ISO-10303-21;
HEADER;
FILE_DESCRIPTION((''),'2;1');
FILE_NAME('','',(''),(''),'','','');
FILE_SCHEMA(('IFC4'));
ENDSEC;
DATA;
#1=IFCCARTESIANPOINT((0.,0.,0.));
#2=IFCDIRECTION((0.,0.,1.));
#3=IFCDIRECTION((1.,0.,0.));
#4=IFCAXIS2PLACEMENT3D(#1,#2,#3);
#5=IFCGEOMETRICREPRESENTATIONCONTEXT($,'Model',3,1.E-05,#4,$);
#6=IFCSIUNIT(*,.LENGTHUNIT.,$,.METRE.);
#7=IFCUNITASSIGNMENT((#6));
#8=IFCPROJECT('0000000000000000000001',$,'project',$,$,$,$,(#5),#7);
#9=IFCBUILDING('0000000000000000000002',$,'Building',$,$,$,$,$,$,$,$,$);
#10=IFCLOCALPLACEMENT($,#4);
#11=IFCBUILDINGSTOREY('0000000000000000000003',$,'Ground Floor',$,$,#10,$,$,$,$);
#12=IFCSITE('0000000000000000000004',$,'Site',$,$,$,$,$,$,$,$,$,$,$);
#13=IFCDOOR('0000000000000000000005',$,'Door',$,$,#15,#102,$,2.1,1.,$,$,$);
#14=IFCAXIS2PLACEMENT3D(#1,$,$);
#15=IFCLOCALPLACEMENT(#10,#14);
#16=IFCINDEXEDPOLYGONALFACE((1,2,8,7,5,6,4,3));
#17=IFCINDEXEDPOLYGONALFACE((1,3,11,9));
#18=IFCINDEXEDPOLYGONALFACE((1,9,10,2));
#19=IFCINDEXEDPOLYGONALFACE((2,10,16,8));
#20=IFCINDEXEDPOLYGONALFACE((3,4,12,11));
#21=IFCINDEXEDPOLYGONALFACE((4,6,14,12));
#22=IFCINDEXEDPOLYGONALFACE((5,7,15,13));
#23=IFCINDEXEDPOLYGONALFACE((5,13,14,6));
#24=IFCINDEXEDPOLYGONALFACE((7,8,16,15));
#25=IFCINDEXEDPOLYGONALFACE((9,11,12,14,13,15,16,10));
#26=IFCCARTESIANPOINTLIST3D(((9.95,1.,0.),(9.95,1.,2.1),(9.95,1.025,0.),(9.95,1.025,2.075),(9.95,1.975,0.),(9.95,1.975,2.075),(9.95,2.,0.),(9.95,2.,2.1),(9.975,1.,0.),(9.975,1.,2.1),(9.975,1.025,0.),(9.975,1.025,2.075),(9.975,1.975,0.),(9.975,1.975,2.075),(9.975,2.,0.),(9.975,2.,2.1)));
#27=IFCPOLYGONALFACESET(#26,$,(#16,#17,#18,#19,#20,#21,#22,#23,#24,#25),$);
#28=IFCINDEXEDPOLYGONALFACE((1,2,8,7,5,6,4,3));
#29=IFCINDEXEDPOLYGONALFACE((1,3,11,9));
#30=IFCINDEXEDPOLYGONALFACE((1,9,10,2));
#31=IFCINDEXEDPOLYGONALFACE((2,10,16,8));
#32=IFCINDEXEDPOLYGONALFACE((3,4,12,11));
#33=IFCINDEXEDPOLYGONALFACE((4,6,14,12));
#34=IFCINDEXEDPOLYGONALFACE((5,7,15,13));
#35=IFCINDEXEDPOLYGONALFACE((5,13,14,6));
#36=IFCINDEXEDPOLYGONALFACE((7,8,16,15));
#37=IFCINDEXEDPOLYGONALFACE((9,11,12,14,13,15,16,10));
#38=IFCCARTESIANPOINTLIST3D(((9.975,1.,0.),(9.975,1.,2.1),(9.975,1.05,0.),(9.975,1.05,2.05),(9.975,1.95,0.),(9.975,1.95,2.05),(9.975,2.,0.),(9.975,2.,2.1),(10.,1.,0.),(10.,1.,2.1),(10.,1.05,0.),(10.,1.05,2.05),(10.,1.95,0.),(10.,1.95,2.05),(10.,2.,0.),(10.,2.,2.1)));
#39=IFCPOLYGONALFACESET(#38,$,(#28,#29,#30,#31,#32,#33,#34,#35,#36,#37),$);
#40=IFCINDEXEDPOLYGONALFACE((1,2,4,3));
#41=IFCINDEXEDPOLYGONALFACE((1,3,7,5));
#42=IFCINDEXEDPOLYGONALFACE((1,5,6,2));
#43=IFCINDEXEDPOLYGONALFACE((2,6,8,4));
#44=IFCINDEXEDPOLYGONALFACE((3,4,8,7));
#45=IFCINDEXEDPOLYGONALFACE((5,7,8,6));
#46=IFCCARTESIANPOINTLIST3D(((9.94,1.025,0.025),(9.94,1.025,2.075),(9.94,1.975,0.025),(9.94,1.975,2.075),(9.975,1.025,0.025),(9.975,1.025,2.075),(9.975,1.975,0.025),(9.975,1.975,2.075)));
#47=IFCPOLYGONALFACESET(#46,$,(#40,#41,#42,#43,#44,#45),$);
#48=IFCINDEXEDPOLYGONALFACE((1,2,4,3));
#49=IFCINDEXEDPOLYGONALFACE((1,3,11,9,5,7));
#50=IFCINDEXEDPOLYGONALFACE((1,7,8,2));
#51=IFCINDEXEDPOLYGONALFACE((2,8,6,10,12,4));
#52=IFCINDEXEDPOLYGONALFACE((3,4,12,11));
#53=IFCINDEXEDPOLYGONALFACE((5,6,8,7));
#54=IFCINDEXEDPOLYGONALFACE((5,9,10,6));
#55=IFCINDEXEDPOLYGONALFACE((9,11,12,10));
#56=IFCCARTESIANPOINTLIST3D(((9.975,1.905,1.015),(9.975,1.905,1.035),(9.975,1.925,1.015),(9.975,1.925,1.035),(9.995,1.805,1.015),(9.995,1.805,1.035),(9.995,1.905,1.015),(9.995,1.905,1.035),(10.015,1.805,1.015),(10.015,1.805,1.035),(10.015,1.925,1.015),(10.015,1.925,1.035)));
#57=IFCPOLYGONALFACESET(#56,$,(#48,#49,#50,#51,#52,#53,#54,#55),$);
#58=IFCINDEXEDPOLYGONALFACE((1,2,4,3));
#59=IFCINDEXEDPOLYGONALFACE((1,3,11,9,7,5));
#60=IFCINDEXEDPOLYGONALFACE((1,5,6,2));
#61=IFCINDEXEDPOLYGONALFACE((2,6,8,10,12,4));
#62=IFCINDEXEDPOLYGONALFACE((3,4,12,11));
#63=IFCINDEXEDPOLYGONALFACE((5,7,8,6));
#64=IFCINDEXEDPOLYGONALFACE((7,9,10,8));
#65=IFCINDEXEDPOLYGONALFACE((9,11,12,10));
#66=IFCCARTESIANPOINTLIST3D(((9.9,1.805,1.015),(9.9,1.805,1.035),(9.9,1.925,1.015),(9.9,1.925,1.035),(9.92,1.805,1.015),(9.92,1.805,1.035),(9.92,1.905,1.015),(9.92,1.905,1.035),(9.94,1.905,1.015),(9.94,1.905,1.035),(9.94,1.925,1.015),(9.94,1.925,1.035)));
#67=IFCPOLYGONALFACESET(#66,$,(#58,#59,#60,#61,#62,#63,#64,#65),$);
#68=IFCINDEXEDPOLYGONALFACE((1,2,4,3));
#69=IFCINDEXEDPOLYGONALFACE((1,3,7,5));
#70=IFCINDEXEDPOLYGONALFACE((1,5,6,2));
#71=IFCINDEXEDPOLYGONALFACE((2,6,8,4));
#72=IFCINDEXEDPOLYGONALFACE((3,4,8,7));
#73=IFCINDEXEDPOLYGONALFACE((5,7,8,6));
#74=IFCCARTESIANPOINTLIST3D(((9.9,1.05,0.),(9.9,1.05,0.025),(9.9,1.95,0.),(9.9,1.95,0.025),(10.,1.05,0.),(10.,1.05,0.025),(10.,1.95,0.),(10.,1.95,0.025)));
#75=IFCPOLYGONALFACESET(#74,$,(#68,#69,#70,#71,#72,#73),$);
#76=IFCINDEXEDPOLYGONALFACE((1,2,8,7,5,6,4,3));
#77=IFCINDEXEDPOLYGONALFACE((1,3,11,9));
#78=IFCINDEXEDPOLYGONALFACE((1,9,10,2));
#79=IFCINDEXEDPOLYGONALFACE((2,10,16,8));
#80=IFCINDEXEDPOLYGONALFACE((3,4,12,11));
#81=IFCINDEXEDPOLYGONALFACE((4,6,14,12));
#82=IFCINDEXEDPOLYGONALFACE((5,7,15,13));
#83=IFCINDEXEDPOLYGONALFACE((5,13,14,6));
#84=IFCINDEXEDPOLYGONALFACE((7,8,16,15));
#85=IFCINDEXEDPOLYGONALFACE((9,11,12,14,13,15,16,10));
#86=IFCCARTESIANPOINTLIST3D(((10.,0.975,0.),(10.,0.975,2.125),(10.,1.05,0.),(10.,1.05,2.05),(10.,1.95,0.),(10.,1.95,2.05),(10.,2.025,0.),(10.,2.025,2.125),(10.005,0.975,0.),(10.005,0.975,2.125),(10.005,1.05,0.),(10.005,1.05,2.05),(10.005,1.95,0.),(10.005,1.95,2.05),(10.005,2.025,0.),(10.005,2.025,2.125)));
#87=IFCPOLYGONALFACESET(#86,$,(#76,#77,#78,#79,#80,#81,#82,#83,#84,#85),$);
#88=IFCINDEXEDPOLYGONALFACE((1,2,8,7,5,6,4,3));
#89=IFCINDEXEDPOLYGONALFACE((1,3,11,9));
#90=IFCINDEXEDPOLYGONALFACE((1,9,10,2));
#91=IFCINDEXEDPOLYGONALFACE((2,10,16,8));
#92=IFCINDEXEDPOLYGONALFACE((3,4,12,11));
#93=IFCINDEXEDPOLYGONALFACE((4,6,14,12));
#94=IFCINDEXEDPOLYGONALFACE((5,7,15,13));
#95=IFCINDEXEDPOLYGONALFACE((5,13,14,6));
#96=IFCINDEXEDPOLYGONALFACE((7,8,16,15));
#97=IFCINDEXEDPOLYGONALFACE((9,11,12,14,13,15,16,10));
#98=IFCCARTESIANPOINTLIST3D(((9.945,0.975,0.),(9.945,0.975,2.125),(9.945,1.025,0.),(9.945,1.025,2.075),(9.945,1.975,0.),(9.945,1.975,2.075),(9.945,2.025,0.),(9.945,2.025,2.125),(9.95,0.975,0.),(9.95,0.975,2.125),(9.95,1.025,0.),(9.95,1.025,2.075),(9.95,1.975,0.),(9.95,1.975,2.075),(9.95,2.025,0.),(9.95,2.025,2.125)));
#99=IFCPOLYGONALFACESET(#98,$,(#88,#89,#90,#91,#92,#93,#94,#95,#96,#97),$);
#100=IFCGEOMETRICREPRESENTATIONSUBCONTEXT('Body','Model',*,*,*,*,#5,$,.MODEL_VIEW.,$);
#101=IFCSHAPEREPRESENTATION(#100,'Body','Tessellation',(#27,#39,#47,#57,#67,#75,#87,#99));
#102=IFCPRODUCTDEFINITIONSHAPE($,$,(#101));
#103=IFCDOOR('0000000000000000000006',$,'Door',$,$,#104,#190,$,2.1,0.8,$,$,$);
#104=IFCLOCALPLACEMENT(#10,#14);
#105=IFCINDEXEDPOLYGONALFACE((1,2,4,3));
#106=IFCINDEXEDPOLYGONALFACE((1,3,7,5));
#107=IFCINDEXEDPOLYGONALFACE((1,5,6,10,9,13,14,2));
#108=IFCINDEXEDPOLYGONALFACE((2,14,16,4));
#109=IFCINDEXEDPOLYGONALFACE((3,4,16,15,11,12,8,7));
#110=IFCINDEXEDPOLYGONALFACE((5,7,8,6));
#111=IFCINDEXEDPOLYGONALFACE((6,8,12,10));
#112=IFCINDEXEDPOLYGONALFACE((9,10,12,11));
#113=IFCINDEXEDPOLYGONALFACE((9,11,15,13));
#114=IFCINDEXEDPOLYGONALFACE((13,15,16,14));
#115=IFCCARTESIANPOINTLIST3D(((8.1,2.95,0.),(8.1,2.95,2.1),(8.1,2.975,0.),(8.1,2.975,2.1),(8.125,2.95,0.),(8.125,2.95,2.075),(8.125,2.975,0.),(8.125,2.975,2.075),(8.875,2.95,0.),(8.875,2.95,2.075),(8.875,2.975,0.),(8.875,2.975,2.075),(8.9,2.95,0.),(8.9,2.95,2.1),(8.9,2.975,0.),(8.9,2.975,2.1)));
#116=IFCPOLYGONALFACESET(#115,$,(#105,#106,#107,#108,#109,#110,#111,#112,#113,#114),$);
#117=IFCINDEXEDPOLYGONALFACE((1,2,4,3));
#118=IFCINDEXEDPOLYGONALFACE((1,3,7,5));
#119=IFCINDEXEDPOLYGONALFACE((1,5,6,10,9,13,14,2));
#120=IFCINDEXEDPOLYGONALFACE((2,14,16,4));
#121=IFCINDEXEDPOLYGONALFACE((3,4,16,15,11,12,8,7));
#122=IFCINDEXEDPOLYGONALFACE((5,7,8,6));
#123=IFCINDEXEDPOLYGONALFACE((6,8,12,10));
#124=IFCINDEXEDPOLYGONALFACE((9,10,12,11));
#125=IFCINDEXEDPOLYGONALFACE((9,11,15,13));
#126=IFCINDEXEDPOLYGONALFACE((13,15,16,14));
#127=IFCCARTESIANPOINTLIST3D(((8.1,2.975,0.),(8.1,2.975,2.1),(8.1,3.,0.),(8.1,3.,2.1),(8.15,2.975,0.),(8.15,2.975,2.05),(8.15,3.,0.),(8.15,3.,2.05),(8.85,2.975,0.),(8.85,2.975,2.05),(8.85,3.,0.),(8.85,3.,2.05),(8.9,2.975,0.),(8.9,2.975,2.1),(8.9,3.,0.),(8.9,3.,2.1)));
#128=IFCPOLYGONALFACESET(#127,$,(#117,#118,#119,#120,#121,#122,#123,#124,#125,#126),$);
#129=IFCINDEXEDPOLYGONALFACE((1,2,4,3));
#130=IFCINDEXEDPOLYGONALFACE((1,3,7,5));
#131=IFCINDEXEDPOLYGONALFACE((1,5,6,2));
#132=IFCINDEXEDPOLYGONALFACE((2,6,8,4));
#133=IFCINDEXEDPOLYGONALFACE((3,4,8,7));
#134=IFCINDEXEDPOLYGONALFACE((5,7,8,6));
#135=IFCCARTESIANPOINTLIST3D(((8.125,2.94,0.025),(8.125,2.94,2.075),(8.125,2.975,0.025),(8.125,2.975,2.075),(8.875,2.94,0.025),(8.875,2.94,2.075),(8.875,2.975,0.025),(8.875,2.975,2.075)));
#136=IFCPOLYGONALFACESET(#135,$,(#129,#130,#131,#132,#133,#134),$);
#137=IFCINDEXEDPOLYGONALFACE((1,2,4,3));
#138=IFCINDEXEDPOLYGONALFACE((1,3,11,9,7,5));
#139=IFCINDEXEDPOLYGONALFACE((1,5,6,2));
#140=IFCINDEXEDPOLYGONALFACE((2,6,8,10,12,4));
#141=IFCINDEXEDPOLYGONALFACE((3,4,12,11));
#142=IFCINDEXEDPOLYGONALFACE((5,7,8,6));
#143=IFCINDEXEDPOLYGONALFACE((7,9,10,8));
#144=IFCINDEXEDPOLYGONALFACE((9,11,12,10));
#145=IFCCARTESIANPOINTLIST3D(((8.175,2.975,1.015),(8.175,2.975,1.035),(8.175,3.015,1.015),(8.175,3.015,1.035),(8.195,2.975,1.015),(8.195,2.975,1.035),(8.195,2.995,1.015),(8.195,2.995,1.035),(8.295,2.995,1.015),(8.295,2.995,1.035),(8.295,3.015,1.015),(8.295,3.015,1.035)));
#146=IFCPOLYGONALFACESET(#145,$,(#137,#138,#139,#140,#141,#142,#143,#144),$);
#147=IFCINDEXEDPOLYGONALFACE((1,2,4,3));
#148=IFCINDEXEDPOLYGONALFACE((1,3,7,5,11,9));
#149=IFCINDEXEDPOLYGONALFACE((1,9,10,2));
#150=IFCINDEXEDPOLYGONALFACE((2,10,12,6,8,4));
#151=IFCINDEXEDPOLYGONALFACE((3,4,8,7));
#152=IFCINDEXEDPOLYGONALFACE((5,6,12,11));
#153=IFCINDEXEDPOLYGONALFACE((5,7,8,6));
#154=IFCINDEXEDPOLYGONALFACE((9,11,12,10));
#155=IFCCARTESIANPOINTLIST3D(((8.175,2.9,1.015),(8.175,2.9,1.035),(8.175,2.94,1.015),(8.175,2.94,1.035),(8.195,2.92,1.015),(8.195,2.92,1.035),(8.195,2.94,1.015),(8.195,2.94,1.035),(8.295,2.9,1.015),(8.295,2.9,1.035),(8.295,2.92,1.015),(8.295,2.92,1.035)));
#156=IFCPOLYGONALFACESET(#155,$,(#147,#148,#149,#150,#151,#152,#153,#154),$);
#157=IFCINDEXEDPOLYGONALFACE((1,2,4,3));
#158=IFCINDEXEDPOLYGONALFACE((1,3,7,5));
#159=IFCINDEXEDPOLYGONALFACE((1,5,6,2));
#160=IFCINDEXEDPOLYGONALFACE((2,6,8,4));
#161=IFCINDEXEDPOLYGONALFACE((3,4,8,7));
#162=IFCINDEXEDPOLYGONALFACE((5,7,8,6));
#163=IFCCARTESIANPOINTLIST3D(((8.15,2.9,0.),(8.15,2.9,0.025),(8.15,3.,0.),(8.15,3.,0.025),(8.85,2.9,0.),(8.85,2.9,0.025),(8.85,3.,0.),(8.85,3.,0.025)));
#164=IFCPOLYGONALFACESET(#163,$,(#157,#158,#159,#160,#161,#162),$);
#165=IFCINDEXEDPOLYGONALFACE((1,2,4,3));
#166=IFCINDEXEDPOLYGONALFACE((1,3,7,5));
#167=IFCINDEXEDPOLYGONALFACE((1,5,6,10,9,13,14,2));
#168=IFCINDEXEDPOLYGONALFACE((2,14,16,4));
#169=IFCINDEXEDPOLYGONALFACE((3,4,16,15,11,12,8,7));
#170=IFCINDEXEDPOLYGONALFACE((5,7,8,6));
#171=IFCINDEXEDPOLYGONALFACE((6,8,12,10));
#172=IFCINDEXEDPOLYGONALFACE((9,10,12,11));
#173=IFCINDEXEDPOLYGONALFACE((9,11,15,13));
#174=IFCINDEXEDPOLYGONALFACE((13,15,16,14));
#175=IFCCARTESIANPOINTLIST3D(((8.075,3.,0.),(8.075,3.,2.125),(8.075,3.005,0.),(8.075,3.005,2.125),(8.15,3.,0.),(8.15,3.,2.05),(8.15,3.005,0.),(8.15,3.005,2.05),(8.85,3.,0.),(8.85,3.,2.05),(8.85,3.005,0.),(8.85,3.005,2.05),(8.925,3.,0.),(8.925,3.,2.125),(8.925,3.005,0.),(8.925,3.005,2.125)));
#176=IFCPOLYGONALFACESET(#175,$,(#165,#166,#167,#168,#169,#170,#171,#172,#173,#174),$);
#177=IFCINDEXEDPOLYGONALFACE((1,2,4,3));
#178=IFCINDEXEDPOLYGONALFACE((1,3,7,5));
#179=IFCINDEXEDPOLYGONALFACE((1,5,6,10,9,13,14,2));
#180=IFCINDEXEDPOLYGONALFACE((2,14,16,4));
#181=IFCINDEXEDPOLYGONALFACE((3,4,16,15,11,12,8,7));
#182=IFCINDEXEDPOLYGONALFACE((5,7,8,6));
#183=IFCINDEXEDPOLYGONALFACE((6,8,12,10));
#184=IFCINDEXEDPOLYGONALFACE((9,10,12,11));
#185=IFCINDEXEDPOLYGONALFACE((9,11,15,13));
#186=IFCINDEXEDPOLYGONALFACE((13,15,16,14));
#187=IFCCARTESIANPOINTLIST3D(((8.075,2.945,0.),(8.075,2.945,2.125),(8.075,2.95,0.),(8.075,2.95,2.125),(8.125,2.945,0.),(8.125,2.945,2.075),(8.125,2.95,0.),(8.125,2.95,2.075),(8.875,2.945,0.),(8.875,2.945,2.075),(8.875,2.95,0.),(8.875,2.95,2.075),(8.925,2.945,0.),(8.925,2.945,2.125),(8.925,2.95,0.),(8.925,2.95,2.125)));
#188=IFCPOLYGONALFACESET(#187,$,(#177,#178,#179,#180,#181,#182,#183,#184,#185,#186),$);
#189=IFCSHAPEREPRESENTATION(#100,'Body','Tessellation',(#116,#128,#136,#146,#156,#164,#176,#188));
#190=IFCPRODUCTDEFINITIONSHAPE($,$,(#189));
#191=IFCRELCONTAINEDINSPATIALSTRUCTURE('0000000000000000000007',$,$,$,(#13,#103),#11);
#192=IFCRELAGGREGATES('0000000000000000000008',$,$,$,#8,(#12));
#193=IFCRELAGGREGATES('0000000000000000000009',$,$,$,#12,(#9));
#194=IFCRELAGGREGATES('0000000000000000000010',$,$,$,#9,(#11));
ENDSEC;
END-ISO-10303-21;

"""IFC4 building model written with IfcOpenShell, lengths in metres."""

from ifc_helpers import new_model, si_unit, frame, origin_with_axes, place, context, subcontext, project, spatial, line, indexed_curve, outline, extrude, element, save


model = new_model("IFC4")

# Units and contexts
model_context = context("Model", 3, precision=1e-05, world=origin_with_axes())
body_context = subcontext(model_context, "Body", "Model", "MODEL_VIEW")
ifc_project = project(units=[si_unit("LENGTHUNIT", "METRE")], contexts=[model_context])

# Site, building, storey
site = spatial("IfcSite", under=ifc_project, Name="Site")
building = spatial("IfcBuilding", under=site, Name="Building")
storey_placement = place(None, origin_with_axes())
storey = spatial("IfcBuildingStorey", under=building, at=storey_placement, Name="Ground Floor")

# Doors
door_1_placement = place(storey_placement, frame((10.0, 1.0, 0.0), z_axis=(0.0, 0.0, 1.0), x_axis=(0.0, 1.0, 0.0)))
element("IfcDoor", 1, at=door_1_placement, inside=storey, Name="Door", OverallHeight=2.1, OverallWidth=1.0, context=body_context, shape_type="SweptSolid", body=[
    extrude(outline(indexed_curve([(0.0, 0.0), (0.0, 2.1), (1.0, 2.1), (1.0, 0.0), (0.975, 0.0), (0.975, 2.075), (0.025, 2.075), (0.025, 0.0)], segments=[line(1, 2, 3, 4, 5, 6, 7, 8, 1)])), frame((0.0, 0.025, 0.0), z_axis=(0.0, -1.0, 0.0), x_axis=(1.0, 0.0, 0.0)), (0.0, 0.0, -1.0), 0.025),
    extrude(outline(indexed_curve([(0.0, 0.0), (0.0, 2.1), (1.0, 2.1), (1.0, 0.0), (0.95, 0.0), (0.95, 2.05), (0.05, 2.05), (0.05, 0.0)], segments=[line(1, 2, 3, 4, 5, 6, 7, 8, 1)])), frame((0.0, 0.0, 0.0), z_axis=(0.0, -1.0, 0.0), x_axis=(1.0, 0.0, 0.0)), (0.0, 0.0, -1.0), 0.025),
    extrude(outline(indexed_curve([(0.0, 0.0), (0.95, 0.0), (0.95, 0.035), (0.0, 0.035)], segments=[line(1, 2, 3, 4, 1)])), frame((0.025, 0.025, 0.025), z_axis=(0.0, 0.0, 1.0), x_axis=(1.0, 0.0, 0.0)), (0.0, 0.0, 1.0), 2.05),
    extrude(outline(indexed_curve([(0.0, 0.0), (0.0, -0.04), (-0.12, -0.04), (-0.12, -0.02), (-0.02, -0.02), (-0.02, 0.0)], segments=[line(1, 2, 3, 4, 5, 6, 1)])), frame((0.925, 0.025, 1.015), z_axis=(0.0, 0.0, 1.0), x_axis=(1.0, 0.0, 0.0)), (0.0, 0.0, 1.0), 0.02),
    extrude(outline(indexed_curve([(0.0, 0.0), (0.0, 0.04), (-0.12, 0.04), (-0.12, 0.02), (-0.02, 0.02), (-0.02, 0.0)], segments=[line(1, 2, 3, 4, 5, 6, 1)])), frame((0.925, 0.06, 1.015), z_axis=(0.0, 0.0, 1.0), x_axis=(1.0, 0.0, 0.0)), (0.0, 0.0, 1.0), 0.02),
    extrude(outline(indexed_curve([(0.0, 0.0), (0.9, 0.0), (0.9, 0.1), (0.0, 0.1)], segments=[line(1, 2, 3, 4, 1)])), frame((0.05, 0.0, 0.0), z_axis=(0.0, 0.0, 1.0), x_axis=(1.0, 0.0, 0.0)), (0.0, 0.0, 1.0), 0.025),
    extrude(outline(indexed_curve([(0.0, 0.0), (0.0, 2.125), (1.05, 2.125), (1.05, 0.0), (0.975, 0.0), (0.975, 2.05), (0.075, 2.05), (0.075, 0.0)], segments=[line(1, 2, 3, 4, 5, 6, 7, 8, 1)])), frame((-0.025, -0.005, 0.0), z_axis=(0.0, -1.0, 0.0), x_axis=(1.0, 0.0, 0.0)), (0.0, 0.0, -1.0), 0.005),
    extrude(outline(indexed_curve([(0.0, 0.0), (0.0, 2.125), (1.05, 2.125), (1.05, 0.0), (1.0, 0.0), (1.0, 2.075), (0.05, 2.075), (0.05, 0.0)], segments=[line(1, 2, 3, 4, 5, 6, 7, 8, 1)])), frame((-0.025, 0.05, 0.0), z_axis=(0.0, -1.0, 0.0), x_axis=(1.0, 0.0, 0.0)), (0.0, 0.0, -1.0), 0.005),
])
door_2_placement = place(storey_placement, frame((8.9, 3.0, 0.0), z_axis=(0.0, 0.0, 1.0), x_axis=(-1.0, 0.0, 0.0)))
element("IfcDoor", 2, at=door_2_placement, inside=storey, Name="Door", OverallHeight=2.1, OverallWidth=0.8, context=body_context, shape_type="SweptSolid", body=[
    extrude(outline(indexed_curve([(0.0, 0.0), (0.0, 2.1), (0.8, 2.1), (0.8, 0.0), (0.775, 0.0), (0.775, 2.075), (0.025, 2.075), (0.025, 0.0)], segments=[line(1, 2, 3, 4, 5, 6, 7, 8, 1)])), frame((0.0, 0.025, 0.0), z_axis=(0.0, -1.0, 0.0), x_axis=(1.0, 0.0, 0.0)), (0.0, 0.0, -1.0), 0.025),
    extrude(outline(indexed_curve([(0.0, 0.0), (0.0, 2.1), (0.8, 2.1), (0.8, 0.0), (0.75, 0.0), (0.75, 2.05), (0.05, 2.05), (0.05, 0.0)], segments=[line(1, 2, 3, 4, 5, 6, 7, 8, 1)])), frame((0.0, 0.0, 0.0), z_axis=(0.0, -1.0, 0.0), x_axis=(1.0, 0.0, 0.0)), (0.0, 0.0, -1.0), 0.025),
    extrude(outline(indexed_curve([(0.0, 0.0), (0.75, 0.0), (0.75, 0.035), (0.0, 0.035)], segments=[line(1, 2, 3, 4, 1)])), frame((0.025, 0.025, 0.025), z_axis=(0.0, 0.0, 1.0), x_axis=(1.0, 0.0, 0.0)), (0.0, 0.0, 1.0), 2.05),
    extrude(outline(indexed_curve([(0.0, 0.0), (0.0, -0.04), (-0.12, -0.04), (-0.12, -0.02), (-0.02, -0.02), (-0.02, 0.0)], segments=[line(1, 2, 3, 4, 5, 6, 1)])), frame((0.725, 0.025, 1.015), z_axis=(0.0, 0.0, 1.0), x_axis=(1.0, 0.0, 0.0)), (0.0, 0.0, 1.0), 0.02),
    extrude(outline(indexed_curve([(0.0, 0.0), (0.0, 0.04), (-0.12, 0.04), (-0.12, 0.02), (-0.02, 0.02), (-0.02, 0.0)], segments=[line(1, 2, 3, 4, 5, 6, 1)])), frame((0.725, 0.06, 1.015), z_axis=(0.0, 0.0, 1.0), x_axis=(1.0, 0.0, 0.0)), (0.0, 0.0, 1.0), 0.02),
    extrude(outline(indexed_curve([(0.0, 0.0), (0.7, 0.0), (0.7, 0.1), (0.0, 0.1)], segments=[line(1, 2, 3, 4, 1)])), frame((0.05, 0.0, 0.0), z_axis=(0.0, 0.0, 1.0), x_axis=(1.0, 0.0, 0.0)), (0.0, 0.0, 1.0), 0.025),
    extrude(outline(indexed_curve([(0.0, 0.0), (0.0, 2.125), (0.85, 2.125), (0.85, 0.0), (0.775, 0.0), (0.775, 2.05), (0.075, 2.05), (0.075, 0.0)], segments=[line(1, 2, 3, 4, 5, 6, 7, 8, 1)])), frame((-0.025, -0.005, 0.0), z_axis=(0.0, -1.0, 0.0), x_axis=(1.0, 0.0, 0.0)), (0.0, 0.0, -1.0), 0.005),
    extrude(outline(indexed_curve([(0.0, 0.0), (0.0, 2.125), (0.85, 2.125), (0.85, 0.0), (0.8, 0.0), (0.8, 2.075), (0.05, 2.075), (0.05, 0.0)], segments=[line(1, 2, 3, 4, 5, 6, 7, 8, 1)])), frame((-0.025, 0.05, 0.0), z_axis=(0.0, -1.0, 0.0), x_axis=(1.0, 0.0, 0.0)), (0.0, 0.0, -1.0), 0.005),
])

save(model, "model.ifc")
